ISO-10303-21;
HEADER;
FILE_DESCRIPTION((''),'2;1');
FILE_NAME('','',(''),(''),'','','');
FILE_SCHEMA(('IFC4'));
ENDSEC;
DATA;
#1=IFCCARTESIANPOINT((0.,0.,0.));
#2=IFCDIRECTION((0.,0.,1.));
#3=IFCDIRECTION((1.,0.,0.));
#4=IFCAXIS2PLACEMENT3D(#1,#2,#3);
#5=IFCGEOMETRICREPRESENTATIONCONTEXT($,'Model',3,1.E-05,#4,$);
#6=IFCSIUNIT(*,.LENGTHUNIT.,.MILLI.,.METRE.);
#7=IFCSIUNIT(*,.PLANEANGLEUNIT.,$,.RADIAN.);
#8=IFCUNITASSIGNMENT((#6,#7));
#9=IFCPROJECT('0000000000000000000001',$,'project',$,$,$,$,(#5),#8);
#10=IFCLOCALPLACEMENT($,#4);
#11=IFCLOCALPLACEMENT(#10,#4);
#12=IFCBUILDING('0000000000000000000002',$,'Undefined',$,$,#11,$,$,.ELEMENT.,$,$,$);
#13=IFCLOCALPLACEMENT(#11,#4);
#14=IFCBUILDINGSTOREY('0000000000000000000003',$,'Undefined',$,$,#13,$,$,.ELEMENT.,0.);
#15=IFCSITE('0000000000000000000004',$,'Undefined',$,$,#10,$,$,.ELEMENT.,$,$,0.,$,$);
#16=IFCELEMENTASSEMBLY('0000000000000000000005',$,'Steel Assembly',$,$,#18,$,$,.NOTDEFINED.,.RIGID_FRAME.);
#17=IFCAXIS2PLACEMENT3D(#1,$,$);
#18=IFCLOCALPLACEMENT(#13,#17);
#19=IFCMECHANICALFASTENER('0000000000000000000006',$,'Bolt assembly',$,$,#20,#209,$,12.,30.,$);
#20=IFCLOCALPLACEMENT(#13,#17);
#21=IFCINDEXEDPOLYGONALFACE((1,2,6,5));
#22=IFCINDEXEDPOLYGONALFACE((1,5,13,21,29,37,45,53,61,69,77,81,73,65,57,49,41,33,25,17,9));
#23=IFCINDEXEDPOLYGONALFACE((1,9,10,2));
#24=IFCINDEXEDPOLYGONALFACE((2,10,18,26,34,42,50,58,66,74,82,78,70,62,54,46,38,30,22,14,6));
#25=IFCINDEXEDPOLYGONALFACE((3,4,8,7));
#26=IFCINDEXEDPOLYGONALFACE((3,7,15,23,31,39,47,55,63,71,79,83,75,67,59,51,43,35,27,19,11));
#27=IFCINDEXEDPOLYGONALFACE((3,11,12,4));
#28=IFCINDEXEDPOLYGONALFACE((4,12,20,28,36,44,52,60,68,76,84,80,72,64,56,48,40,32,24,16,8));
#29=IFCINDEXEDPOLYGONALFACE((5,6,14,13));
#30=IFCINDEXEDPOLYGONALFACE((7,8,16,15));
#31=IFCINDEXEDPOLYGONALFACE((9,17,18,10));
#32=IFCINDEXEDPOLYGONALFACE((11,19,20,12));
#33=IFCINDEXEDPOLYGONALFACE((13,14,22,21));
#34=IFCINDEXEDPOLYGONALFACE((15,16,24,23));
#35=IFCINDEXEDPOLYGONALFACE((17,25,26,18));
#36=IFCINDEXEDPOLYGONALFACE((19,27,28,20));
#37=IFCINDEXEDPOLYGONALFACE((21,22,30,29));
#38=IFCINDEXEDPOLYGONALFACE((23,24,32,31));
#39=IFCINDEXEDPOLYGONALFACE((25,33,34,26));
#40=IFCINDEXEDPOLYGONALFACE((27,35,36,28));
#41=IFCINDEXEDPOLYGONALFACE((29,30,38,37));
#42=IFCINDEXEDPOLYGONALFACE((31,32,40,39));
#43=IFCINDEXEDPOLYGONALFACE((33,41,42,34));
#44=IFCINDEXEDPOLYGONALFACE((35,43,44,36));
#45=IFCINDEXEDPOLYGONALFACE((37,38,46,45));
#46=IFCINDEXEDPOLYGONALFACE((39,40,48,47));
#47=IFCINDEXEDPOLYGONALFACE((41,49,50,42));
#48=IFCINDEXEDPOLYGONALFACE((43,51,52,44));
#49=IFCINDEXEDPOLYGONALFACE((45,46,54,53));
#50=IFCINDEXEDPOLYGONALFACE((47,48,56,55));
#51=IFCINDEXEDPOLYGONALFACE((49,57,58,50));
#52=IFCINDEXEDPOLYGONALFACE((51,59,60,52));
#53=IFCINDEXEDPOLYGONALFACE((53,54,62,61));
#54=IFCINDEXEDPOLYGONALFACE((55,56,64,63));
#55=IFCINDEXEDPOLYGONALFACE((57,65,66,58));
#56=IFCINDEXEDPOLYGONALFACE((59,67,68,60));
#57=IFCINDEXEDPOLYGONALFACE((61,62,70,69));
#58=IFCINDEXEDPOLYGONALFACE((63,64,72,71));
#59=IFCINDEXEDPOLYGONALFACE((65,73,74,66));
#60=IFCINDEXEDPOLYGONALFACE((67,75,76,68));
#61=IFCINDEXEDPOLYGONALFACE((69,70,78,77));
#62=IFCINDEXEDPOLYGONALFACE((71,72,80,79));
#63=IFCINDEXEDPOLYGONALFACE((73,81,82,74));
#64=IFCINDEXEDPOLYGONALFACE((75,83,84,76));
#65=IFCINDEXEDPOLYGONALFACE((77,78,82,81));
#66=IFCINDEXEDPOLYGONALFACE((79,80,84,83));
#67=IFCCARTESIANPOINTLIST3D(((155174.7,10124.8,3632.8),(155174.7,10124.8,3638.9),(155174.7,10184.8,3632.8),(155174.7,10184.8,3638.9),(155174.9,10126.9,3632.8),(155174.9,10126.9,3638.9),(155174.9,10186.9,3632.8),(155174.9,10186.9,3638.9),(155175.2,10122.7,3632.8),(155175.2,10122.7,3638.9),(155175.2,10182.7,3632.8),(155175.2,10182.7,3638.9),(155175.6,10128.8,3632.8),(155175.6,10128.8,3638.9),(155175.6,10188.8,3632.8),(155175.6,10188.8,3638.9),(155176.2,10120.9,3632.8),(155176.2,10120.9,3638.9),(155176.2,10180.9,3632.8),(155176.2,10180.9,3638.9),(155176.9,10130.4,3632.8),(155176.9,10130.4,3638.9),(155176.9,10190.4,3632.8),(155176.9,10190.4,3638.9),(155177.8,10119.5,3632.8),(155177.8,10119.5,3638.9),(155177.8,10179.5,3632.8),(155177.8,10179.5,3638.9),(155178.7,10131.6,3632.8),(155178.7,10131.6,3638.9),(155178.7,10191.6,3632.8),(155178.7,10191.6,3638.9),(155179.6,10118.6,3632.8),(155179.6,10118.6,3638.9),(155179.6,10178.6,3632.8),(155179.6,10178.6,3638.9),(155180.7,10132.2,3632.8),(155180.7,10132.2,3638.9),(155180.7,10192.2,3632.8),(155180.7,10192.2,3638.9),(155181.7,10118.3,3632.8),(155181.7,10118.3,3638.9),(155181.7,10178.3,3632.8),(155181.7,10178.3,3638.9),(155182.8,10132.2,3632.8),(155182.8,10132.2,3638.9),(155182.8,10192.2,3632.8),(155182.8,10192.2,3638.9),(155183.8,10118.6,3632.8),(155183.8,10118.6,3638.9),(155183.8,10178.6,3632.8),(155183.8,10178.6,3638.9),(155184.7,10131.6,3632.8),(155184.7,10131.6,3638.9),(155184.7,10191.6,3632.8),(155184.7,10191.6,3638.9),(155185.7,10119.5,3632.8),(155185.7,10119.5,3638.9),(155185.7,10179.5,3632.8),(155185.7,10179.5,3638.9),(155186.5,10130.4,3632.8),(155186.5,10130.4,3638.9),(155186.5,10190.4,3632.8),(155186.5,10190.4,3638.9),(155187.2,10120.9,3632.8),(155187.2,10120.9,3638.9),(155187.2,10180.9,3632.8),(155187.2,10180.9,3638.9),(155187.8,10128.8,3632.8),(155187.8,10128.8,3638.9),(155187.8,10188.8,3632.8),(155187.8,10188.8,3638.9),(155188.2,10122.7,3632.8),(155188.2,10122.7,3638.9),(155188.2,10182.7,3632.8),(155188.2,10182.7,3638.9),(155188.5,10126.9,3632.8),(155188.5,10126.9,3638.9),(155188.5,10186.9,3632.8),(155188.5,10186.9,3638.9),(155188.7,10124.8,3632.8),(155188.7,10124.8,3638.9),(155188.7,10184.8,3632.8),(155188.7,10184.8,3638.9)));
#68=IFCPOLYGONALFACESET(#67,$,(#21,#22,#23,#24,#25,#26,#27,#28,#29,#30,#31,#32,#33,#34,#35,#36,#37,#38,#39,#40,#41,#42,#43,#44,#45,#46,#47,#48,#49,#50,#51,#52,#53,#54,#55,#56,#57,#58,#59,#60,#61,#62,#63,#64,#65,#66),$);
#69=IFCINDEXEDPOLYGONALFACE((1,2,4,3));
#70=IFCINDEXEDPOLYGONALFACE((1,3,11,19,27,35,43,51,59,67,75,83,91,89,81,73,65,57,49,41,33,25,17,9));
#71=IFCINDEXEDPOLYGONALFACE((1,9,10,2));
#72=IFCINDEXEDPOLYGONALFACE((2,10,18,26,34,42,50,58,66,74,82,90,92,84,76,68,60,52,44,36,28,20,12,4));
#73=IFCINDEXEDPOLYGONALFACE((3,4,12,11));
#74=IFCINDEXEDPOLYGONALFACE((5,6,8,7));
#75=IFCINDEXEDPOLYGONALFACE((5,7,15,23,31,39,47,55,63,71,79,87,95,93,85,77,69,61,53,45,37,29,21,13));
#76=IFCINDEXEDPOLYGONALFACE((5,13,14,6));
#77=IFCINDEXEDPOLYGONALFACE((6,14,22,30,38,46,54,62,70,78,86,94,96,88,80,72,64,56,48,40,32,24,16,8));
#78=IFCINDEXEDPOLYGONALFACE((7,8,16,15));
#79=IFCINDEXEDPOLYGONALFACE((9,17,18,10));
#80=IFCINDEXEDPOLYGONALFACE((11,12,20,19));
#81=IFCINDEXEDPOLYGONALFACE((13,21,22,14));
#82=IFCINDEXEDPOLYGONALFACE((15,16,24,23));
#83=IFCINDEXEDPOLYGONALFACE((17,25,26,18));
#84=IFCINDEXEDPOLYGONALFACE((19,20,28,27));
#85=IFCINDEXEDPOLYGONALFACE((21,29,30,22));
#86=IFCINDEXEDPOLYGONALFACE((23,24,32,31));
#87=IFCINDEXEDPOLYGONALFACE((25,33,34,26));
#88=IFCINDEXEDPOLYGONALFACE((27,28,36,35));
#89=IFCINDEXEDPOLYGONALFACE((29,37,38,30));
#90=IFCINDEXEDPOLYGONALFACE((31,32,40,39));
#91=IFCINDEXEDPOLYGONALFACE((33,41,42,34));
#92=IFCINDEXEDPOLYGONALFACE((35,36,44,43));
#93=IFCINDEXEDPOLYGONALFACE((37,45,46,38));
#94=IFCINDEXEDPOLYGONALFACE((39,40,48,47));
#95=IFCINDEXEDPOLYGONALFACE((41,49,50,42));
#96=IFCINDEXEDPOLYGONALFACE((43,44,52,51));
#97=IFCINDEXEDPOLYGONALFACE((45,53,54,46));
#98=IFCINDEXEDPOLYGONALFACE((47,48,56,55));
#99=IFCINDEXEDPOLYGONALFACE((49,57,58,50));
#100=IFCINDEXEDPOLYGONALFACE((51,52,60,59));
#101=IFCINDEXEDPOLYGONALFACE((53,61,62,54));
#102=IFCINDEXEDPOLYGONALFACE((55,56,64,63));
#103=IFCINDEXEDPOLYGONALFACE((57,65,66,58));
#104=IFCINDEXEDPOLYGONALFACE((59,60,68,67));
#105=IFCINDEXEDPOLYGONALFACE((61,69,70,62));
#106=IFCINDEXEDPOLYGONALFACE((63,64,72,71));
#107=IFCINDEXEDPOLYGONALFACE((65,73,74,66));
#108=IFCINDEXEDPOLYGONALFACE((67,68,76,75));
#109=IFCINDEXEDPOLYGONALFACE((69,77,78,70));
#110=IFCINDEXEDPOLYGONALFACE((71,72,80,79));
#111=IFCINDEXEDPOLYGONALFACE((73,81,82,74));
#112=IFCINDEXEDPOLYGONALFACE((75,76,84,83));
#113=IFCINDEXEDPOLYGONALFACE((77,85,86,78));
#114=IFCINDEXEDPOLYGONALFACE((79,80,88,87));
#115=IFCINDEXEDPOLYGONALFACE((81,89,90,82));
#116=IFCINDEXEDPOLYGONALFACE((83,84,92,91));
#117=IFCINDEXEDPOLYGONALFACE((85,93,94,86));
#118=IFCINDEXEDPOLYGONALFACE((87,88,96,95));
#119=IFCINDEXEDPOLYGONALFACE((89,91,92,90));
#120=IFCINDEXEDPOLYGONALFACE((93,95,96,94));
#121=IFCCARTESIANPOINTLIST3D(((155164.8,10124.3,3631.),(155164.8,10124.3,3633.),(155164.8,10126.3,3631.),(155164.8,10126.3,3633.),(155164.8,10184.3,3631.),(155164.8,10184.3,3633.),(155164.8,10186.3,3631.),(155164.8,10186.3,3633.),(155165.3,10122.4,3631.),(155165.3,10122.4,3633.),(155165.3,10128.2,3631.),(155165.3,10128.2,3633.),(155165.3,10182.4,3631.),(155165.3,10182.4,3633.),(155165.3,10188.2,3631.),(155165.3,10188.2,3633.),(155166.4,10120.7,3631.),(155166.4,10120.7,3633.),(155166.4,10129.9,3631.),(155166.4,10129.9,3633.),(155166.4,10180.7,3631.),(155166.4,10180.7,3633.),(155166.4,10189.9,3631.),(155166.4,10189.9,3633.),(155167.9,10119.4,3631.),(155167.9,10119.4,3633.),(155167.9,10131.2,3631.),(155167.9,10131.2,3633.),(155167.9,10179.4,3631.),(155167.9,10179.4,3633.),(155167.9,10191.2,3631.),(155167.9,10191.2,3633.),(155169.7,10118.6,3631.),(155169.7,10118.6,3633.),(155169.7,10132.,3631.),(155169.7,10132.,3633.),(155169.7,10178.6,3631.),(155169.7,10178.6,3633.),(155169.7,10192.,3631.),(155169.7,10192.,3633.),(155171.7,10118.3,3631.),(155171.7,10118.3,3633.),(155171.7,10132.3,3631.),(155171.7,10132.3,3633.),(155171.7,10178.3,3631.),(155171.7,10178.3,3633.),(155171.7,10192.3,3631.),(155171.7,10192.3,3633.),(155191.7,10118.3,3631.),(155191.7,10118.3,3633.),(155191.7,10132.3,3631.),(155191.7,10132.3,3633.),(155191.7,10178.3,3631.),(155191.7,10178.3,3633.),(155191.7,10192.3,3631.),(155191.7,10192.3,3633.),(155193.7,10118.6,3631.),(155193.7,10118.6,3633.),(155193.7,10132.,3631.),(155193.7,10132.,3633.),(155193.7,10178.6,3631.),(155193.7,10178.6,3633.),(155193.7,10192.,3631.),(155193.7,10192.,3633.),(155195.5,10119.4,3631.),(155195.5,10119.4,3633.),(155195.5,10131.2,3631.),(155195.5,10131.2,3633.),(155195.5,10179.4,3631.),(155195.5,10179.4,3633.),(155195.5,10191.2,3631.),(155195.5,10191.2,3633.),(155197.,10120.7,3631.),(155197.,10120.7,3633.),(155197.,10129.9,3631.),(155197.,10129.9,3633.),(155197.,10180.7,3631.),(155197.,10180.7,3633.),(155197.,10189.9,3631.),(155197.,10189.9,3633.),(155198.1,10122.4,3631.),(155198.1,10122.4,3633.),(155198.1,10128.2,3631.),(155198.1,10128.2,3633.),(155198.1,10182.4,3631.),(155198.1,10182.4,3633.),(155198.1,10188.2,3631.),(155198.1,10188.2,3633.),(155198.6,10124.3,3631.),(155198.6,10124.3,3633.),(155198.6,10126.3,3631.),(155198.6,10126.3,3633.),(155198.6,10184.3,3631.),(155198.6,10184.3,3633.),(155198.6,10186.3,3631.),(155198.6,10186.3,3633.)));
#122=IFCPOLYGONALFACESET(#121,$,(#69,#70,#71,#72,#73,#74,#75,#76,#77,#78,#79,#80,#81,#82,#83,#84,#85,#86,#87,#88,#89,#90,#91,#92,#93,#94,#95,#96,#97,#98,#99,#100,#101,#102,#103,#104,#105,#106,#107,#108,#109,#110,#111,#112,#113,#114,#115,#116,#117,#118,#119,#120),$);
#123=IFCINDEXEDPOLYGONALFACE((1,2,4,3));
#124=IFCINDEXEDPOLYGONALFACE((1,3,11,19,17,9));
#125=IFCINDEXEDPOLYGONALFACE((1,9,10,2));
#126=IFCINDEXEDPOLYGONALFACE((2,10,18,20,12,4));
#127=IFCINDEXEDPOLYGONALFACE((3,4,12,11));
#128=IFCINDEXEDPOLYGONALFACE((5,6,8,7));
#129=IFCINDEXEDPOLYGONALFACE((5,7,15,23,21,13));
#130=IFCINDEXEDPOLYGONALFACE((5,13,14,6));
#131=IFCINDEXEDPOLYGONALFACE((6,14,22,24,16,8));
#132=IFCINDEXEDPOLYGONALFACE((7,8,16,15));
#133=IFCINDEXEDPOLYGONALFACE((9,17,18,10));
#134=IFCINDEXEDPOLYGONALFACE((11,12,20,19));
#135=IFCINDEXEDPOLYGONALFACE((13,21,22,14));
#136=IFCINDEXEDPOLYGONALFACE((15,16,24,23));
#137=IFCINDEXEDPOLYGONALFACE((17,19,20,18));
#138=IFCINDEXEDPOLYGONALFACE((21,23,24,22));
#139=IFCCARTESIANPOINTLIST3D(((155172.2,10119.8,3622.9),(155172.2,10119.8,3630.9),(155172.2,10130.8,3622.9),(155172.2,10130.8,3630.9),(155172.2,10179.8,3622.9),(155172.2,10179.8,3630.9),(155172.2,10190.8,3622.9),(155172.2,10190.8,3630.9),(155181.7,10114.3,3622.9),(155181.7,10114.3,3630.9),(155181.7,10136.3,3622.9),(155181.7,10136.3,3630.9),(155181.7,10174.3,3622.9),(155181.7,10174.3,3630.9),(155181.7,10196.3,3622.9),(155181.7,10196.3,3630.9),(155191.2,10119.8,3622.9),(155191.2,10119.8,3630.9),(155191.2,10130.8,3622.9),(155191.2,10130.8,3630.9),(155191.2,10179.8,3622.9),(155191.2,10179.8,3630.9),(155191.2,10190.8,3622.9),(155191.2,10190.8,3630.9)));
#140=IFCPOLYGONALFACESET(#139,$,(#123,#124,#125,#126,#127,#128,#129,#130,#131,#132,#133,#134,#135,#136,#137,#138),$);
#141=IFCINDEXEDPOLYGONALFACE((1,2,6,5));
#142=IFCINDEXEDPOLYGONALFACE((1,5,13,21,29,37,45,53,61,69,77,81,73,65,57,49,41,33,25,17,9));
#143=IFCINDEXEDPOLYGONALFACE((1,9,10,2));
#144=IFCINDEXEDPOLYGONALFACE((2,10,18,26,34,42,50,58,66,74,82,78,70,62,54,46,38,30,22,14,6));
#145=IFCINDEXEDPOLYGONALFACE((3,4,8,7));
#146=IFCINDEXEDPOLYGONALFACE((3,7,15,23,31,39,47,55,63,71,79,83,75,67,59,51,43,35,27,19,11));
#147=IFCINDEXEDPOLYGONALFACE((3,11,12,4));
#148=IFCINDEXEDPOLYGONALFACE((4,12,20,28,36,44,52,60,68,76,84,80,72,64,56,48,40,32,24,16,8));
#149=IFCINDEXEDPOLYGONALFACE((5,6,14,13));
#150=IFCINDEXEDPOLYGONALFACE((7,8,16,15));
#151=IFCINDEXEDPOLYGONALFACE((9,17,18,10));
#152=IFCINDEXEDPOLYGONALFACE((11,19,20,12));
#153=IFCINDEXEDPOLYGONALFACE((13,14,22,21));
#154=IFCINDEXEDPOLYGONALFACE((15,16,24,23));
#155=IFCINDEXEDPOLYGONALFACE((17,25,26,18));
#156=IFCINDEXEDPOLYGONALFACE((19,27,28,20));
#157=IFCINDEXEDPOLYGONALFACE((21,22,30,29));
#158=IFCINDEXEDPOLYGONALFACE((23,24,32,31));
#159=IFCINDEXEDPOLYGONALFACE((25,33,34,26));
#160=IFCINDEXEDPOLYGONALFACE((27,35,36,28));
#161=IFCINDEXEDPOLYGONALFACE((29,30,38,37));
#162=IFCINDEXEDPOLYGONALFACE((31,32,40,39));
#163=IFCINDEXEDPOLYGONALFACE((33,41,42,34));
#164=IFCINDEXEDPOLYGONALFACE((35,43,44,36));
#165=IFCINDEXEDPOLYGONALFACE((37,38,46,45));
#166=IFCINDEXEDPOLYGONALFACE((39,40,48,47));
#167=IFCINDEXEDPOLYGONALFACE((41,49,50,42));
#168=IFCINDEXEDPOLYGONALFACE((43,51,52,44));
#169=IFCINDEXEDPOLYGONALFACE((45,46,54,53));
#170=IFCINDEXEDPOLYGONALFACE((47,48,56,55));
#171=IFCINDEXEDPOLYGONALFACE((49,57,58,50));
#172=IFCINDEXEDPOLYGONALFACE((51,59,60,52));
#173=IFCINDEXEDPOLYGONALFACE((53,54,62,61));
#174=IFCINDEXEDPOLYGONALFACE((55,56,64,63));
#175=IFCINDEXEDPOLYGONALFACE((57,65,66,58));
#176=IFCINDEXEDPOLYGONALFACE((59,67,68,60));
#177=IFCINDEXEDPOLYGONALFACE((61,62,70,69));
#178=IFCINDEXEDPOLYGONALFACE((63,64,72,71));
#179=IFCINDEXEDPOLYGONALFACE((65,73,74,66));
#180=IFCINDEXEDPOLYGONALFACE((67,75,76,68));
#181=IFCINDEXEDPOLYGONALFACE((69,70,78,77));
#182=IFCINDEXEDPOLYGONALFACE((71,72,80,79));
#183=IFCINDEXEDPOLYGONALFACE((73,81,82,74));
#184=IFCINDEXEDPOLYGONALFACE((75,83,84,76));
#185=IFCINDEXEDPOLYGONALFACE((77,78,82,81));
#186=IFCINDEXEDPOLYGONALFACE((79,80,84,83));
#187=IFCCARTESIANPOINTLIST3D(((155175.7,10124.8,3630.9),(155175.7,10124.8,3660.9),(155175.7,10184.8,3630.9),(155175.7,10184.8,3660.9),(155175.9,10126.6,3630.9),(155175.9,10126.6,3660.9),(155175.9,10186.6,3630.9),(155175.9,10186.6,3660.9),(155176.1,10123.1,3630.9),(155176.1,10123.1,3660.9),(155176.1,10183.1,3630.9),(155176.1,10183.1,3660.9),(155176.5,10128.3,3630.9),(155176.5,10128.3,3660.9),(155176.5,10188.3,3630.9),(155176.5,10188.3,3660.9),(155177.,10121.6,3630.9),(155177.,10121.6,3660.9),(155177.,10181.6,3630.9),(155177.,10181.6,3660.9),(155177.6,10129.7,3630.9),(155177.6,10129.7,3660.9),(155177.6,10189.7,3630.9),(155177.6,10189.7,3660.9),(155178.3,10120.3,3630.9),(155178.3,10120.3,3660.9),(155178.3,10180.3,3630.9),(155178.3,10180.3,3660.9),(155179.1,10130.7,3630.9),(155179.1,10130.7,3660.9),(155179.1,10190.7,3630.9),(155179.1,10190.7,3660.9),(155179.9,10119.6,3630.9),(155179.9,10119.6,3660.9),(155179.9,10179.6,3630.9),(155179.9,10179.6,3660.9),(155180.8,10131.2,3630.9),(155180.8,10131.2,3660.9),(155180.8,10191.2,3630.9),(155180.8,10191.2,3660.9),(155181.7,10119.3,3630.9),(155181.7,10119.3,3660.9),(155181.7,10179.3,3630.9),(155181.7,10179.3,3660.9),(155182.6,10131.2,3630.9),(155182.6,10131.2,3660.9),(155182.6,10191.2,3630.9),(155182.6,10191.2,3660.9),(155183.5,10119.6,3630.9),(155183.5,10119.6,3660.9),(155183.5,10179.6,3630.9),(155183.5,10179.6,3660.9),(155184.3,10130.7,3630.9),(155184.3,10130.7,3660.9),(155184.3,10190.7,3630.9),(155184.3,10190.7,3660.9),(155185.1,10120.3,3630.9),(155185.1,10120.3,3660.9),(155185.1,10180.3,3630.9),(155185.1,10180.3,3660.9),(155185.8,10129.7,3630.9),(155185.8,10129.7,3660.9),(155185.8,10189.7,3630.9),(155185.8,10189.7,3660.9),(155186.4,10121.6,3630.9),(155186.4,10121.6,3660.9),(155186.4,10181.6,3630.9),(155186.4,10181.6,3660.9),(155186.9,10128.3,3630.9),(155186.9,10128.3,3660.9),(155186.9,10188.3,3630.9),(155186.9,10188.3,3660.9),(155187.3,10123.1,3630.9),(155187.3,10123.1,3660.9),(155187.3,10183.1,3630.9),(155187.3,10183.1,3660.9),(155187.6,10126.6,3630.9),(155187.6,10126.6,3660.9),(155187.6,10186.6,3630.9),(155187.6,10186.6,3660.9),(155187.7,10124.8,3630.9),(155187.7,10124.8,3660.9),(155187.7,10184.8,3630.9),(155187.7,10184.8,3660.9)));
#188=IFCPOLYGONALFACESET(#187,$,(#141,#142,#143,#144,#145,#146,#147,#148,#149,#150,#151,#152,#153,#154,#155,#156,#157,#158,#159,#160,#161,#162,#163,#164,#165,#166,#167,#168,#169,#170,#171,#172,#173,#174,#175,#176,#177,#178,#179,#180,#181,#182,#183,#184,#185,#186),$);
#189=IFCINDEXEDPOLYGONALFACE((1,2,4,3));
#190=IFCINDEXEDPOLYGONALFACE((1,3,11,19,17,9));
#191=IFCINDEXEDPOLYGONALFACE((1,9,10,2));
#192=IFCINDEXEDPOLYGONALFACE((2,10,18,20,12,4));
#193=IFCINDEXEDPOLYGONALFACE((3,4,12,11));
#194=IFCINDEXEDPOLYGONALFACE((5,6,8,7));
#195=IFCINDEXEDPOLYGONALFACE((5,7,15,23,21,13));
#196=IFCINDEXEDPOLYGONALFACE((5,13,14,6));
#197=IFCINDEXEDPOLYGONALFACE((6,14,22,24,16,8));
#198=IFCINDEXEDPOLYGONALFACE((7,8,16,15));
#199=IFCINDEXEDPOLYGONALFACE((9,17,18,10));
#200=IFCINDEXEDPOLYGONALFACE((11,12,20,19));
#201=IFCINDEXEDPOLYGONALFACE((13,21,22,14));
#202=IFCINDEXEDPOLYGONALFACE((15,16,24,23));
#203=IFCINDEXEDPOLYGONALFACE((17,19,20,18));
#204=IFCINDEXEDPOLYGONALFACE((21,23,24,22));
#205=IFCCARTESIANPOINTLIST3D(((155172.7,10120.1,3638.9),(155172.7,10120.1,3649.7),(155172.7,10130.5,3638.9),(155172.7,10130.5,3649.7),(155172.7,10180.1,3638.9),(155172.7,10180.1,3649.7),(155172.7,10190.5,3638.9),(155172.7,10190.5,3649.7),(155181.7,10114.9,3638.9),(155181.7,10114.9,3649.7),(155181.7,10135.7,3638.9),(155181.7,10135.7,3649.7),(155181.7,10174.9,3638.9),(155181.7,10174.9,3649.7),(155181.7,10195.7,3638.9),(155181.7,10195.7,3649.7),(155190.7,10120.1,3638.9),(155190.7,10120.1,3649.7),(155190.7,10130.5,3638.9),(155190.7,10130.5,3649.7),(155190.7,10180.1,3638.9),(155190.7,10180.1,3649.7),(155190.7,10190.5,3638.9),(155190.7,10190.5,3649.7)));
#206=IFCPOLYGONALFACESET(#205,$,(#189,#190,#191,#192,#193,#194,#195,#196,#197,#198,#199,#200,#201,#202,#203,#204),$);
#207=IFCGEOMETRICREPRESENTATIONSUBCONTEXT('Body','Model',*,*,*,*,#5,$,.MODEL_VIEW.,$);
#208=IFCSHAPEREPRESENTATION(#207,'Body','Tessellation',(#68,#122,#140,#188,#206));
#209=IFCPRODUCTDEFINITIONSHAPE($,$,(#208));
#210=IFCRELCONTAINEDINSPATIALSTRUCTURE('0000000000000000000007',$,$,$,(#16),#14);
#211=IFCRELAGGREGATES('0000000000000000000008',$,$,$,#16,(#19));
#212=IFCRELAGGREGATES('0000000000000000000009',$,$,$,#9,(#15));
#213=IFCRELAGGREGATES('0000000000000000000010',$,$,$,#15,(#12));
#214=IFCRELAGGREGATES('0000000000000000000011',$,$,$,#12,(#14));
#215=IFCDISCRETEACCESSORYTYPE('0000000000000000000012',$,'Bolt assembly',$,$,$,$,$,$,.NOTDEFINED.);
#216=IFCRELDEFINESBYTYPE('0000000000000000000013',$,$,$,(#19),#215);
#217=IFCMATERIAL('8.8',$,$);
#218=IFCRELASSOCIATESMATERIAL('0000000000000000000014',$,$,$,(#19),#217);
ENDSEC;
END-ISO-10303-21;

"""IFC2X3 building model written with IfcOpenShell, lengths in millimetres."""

from ifc_helpers import new_model, si_unit, frame, frame_2d, origin_with_axes, origin_2d_with_axis, place, context, subcontext, project, spatial, polyline, circle_curve, parameter, trimmed, segment, composite_curve, circle, outline, extrude, source, transform, mapped, material, type_object, element, aggregate, save


model = new_model("IFC2X3")

# Units and contexts
model_context = context("Model", 3, precision=1e-05, world=origin_with_axes())
body_context = subcontext(model_context, "Body", "Model", "MODEL_VIEW")
ifc_project = project(units=[si_unit("LENGTHUNIT", "METRE", prefix="MILLI"), si_unit("PLANEANGLEUNIT", "RADIAN")], contexts=[model_context])

# Site, building, storey
site_placement = place(None, origin_with_axes())
site = spatial("IfcSite", under=ifc_project, at=site_placement, Name="Undefined", CompositionType="ELEMENT", RefElevation=0.0)
building_placement = place(site_placement, origin_with_axes())
building = spatial("IfcBuilding", under=site, at=building_placement, Name="Undefined", CompositionType="ELEMENT")
storey_placement = place(building_placement, origin_with_axes())
storey = spatial("IfcBuildingStorey", under=building, at=storey_placement, Name="Undefined", CompositionType="ELEMENT", Elevation=0.0)

# Shared definitions
discrete_accessory_type_1 = type_object("IfcDiscreteAccessoryType", Name="Bolt assembly")

# Element assembly, mechanical fastener
assembly_1_placement = place(storey_placement, origin_with_axes())
assembly_1 = element("IfcElementAssembly", 1, at=assembly_1_placement, inside=storey, Name="Steel Assembly", AssemblyPlace="NOTDEFINED", PredefinedType="RIGID_FRAME")
ifc_material_1 = material(Name="8.8")
shared_shape_1 = source(origin_with_axes(), body_context, "Body", "SweptSolid", [
    extrude(circle(Radius=7.0, at=origin_2d_with_axis()), frame((0.0, -3.1, 0.0), z_axis=(0.0, 1.0, 0.0), x_axis=(1.0, 0.0, 0.0)), (0.0, 0.0, 1.0), 6.1),
    extrude(outline(composite_curve([segment(polyline([(7.0, 10.0), (7.0, -10.0)]), True, "CONTINUOUS"), segment(trimmed(circle_curve(frame_2d((0.0, -10.0), x_axis=(1.0, 0.0)), 7.0), [parameter(0.0)], [parameter(3.1416)], False, "PARAMETER"), True, "CONTINUOUS"), segment(polyline([(-7.0, -10.0), (-7.0, 10.0)]), True, "CONTINUOUS"), segment(trimmed(circle_curve(frame_2d((0.0, 10.0), x_axis=(-1.0, 0.0)), 7.0), [parameter(0.0)], [parameter(3.1416)], False, "PARAMETER"), True, "DISCONTINUOUS")], self_intersect=False)), frame((0.0, -4.9, 0.0), z_axis=(0.0, 1.0, 0.0), x_axis=(1.0, 0.0, 0.0)), (0.0, 0.0, 1.0), 2.0),
    extrude(outline(polyline([(11.0, 0.0), (5.5, 9.5), (-5.5, 9.5), (-11.0, 0.0), (-5.5, -9.5), (5.5, -9.5), (11.0, 0.0)])), frame((0.0, -13.0, 0.0), z_axis=(0.0, 1.0, 0.0), x_axis=(1.0, 0.0, 0.0)), (0.0, 0.0, 1.0), 8.0),
    extrude(circle(Radius=6.0, at=origin_2d_with_axis()), frame((0.0, -5.0, 0.0), z_axis=(0.0, 1.0, 0.0), x_axis=(1.0, 0.0, 0.0)), (0.0, 0.0, 1.0), 30.0),
    extrude(outline(polyline([(10.4, 0.0), (5.2, 9.0), (-5.2, 9.0), (-10.4, 0.0), (-5.2, -9.0), (5.2, -9.0), (10.4, 0.0)])), frame((0.0, 3.0, 0.0), z_axis=(0.0, 1.0, 0.0), x_axis=(1.0, 0.0, 0.0)), (0.0, 0.0, 1.0), 10.8),
])
mechanical_fastener_1_placement = place(assembly_1_placement, frame((155226.7, 10230.3, 3635.9), z_axis=(-1.0, 0.0, 0.0), x_axis=(0.0, -1.0, 0.0)))
mechanical_fastener_1 = element("IfcMechanicalFastener", 2, at=mechanical_fastener_1_placement, type_object=discrete_accessory_type_1, material=ifc_material_1, Name="Bolt assembly", NominalDiameter=12.0, NominalLength=30.0, context=body_context, shape_type="MappedRepresentation", body=[
    mapped(shared_shape_1, transform((45.0, 0.0, 45.0))),
    mapped(shared_shape_1, transform((105.0, 0.0, 45.0))),
])
aggregate(assembly_1, [mechanical_fastener_1])

save(model, "model.ifc")
